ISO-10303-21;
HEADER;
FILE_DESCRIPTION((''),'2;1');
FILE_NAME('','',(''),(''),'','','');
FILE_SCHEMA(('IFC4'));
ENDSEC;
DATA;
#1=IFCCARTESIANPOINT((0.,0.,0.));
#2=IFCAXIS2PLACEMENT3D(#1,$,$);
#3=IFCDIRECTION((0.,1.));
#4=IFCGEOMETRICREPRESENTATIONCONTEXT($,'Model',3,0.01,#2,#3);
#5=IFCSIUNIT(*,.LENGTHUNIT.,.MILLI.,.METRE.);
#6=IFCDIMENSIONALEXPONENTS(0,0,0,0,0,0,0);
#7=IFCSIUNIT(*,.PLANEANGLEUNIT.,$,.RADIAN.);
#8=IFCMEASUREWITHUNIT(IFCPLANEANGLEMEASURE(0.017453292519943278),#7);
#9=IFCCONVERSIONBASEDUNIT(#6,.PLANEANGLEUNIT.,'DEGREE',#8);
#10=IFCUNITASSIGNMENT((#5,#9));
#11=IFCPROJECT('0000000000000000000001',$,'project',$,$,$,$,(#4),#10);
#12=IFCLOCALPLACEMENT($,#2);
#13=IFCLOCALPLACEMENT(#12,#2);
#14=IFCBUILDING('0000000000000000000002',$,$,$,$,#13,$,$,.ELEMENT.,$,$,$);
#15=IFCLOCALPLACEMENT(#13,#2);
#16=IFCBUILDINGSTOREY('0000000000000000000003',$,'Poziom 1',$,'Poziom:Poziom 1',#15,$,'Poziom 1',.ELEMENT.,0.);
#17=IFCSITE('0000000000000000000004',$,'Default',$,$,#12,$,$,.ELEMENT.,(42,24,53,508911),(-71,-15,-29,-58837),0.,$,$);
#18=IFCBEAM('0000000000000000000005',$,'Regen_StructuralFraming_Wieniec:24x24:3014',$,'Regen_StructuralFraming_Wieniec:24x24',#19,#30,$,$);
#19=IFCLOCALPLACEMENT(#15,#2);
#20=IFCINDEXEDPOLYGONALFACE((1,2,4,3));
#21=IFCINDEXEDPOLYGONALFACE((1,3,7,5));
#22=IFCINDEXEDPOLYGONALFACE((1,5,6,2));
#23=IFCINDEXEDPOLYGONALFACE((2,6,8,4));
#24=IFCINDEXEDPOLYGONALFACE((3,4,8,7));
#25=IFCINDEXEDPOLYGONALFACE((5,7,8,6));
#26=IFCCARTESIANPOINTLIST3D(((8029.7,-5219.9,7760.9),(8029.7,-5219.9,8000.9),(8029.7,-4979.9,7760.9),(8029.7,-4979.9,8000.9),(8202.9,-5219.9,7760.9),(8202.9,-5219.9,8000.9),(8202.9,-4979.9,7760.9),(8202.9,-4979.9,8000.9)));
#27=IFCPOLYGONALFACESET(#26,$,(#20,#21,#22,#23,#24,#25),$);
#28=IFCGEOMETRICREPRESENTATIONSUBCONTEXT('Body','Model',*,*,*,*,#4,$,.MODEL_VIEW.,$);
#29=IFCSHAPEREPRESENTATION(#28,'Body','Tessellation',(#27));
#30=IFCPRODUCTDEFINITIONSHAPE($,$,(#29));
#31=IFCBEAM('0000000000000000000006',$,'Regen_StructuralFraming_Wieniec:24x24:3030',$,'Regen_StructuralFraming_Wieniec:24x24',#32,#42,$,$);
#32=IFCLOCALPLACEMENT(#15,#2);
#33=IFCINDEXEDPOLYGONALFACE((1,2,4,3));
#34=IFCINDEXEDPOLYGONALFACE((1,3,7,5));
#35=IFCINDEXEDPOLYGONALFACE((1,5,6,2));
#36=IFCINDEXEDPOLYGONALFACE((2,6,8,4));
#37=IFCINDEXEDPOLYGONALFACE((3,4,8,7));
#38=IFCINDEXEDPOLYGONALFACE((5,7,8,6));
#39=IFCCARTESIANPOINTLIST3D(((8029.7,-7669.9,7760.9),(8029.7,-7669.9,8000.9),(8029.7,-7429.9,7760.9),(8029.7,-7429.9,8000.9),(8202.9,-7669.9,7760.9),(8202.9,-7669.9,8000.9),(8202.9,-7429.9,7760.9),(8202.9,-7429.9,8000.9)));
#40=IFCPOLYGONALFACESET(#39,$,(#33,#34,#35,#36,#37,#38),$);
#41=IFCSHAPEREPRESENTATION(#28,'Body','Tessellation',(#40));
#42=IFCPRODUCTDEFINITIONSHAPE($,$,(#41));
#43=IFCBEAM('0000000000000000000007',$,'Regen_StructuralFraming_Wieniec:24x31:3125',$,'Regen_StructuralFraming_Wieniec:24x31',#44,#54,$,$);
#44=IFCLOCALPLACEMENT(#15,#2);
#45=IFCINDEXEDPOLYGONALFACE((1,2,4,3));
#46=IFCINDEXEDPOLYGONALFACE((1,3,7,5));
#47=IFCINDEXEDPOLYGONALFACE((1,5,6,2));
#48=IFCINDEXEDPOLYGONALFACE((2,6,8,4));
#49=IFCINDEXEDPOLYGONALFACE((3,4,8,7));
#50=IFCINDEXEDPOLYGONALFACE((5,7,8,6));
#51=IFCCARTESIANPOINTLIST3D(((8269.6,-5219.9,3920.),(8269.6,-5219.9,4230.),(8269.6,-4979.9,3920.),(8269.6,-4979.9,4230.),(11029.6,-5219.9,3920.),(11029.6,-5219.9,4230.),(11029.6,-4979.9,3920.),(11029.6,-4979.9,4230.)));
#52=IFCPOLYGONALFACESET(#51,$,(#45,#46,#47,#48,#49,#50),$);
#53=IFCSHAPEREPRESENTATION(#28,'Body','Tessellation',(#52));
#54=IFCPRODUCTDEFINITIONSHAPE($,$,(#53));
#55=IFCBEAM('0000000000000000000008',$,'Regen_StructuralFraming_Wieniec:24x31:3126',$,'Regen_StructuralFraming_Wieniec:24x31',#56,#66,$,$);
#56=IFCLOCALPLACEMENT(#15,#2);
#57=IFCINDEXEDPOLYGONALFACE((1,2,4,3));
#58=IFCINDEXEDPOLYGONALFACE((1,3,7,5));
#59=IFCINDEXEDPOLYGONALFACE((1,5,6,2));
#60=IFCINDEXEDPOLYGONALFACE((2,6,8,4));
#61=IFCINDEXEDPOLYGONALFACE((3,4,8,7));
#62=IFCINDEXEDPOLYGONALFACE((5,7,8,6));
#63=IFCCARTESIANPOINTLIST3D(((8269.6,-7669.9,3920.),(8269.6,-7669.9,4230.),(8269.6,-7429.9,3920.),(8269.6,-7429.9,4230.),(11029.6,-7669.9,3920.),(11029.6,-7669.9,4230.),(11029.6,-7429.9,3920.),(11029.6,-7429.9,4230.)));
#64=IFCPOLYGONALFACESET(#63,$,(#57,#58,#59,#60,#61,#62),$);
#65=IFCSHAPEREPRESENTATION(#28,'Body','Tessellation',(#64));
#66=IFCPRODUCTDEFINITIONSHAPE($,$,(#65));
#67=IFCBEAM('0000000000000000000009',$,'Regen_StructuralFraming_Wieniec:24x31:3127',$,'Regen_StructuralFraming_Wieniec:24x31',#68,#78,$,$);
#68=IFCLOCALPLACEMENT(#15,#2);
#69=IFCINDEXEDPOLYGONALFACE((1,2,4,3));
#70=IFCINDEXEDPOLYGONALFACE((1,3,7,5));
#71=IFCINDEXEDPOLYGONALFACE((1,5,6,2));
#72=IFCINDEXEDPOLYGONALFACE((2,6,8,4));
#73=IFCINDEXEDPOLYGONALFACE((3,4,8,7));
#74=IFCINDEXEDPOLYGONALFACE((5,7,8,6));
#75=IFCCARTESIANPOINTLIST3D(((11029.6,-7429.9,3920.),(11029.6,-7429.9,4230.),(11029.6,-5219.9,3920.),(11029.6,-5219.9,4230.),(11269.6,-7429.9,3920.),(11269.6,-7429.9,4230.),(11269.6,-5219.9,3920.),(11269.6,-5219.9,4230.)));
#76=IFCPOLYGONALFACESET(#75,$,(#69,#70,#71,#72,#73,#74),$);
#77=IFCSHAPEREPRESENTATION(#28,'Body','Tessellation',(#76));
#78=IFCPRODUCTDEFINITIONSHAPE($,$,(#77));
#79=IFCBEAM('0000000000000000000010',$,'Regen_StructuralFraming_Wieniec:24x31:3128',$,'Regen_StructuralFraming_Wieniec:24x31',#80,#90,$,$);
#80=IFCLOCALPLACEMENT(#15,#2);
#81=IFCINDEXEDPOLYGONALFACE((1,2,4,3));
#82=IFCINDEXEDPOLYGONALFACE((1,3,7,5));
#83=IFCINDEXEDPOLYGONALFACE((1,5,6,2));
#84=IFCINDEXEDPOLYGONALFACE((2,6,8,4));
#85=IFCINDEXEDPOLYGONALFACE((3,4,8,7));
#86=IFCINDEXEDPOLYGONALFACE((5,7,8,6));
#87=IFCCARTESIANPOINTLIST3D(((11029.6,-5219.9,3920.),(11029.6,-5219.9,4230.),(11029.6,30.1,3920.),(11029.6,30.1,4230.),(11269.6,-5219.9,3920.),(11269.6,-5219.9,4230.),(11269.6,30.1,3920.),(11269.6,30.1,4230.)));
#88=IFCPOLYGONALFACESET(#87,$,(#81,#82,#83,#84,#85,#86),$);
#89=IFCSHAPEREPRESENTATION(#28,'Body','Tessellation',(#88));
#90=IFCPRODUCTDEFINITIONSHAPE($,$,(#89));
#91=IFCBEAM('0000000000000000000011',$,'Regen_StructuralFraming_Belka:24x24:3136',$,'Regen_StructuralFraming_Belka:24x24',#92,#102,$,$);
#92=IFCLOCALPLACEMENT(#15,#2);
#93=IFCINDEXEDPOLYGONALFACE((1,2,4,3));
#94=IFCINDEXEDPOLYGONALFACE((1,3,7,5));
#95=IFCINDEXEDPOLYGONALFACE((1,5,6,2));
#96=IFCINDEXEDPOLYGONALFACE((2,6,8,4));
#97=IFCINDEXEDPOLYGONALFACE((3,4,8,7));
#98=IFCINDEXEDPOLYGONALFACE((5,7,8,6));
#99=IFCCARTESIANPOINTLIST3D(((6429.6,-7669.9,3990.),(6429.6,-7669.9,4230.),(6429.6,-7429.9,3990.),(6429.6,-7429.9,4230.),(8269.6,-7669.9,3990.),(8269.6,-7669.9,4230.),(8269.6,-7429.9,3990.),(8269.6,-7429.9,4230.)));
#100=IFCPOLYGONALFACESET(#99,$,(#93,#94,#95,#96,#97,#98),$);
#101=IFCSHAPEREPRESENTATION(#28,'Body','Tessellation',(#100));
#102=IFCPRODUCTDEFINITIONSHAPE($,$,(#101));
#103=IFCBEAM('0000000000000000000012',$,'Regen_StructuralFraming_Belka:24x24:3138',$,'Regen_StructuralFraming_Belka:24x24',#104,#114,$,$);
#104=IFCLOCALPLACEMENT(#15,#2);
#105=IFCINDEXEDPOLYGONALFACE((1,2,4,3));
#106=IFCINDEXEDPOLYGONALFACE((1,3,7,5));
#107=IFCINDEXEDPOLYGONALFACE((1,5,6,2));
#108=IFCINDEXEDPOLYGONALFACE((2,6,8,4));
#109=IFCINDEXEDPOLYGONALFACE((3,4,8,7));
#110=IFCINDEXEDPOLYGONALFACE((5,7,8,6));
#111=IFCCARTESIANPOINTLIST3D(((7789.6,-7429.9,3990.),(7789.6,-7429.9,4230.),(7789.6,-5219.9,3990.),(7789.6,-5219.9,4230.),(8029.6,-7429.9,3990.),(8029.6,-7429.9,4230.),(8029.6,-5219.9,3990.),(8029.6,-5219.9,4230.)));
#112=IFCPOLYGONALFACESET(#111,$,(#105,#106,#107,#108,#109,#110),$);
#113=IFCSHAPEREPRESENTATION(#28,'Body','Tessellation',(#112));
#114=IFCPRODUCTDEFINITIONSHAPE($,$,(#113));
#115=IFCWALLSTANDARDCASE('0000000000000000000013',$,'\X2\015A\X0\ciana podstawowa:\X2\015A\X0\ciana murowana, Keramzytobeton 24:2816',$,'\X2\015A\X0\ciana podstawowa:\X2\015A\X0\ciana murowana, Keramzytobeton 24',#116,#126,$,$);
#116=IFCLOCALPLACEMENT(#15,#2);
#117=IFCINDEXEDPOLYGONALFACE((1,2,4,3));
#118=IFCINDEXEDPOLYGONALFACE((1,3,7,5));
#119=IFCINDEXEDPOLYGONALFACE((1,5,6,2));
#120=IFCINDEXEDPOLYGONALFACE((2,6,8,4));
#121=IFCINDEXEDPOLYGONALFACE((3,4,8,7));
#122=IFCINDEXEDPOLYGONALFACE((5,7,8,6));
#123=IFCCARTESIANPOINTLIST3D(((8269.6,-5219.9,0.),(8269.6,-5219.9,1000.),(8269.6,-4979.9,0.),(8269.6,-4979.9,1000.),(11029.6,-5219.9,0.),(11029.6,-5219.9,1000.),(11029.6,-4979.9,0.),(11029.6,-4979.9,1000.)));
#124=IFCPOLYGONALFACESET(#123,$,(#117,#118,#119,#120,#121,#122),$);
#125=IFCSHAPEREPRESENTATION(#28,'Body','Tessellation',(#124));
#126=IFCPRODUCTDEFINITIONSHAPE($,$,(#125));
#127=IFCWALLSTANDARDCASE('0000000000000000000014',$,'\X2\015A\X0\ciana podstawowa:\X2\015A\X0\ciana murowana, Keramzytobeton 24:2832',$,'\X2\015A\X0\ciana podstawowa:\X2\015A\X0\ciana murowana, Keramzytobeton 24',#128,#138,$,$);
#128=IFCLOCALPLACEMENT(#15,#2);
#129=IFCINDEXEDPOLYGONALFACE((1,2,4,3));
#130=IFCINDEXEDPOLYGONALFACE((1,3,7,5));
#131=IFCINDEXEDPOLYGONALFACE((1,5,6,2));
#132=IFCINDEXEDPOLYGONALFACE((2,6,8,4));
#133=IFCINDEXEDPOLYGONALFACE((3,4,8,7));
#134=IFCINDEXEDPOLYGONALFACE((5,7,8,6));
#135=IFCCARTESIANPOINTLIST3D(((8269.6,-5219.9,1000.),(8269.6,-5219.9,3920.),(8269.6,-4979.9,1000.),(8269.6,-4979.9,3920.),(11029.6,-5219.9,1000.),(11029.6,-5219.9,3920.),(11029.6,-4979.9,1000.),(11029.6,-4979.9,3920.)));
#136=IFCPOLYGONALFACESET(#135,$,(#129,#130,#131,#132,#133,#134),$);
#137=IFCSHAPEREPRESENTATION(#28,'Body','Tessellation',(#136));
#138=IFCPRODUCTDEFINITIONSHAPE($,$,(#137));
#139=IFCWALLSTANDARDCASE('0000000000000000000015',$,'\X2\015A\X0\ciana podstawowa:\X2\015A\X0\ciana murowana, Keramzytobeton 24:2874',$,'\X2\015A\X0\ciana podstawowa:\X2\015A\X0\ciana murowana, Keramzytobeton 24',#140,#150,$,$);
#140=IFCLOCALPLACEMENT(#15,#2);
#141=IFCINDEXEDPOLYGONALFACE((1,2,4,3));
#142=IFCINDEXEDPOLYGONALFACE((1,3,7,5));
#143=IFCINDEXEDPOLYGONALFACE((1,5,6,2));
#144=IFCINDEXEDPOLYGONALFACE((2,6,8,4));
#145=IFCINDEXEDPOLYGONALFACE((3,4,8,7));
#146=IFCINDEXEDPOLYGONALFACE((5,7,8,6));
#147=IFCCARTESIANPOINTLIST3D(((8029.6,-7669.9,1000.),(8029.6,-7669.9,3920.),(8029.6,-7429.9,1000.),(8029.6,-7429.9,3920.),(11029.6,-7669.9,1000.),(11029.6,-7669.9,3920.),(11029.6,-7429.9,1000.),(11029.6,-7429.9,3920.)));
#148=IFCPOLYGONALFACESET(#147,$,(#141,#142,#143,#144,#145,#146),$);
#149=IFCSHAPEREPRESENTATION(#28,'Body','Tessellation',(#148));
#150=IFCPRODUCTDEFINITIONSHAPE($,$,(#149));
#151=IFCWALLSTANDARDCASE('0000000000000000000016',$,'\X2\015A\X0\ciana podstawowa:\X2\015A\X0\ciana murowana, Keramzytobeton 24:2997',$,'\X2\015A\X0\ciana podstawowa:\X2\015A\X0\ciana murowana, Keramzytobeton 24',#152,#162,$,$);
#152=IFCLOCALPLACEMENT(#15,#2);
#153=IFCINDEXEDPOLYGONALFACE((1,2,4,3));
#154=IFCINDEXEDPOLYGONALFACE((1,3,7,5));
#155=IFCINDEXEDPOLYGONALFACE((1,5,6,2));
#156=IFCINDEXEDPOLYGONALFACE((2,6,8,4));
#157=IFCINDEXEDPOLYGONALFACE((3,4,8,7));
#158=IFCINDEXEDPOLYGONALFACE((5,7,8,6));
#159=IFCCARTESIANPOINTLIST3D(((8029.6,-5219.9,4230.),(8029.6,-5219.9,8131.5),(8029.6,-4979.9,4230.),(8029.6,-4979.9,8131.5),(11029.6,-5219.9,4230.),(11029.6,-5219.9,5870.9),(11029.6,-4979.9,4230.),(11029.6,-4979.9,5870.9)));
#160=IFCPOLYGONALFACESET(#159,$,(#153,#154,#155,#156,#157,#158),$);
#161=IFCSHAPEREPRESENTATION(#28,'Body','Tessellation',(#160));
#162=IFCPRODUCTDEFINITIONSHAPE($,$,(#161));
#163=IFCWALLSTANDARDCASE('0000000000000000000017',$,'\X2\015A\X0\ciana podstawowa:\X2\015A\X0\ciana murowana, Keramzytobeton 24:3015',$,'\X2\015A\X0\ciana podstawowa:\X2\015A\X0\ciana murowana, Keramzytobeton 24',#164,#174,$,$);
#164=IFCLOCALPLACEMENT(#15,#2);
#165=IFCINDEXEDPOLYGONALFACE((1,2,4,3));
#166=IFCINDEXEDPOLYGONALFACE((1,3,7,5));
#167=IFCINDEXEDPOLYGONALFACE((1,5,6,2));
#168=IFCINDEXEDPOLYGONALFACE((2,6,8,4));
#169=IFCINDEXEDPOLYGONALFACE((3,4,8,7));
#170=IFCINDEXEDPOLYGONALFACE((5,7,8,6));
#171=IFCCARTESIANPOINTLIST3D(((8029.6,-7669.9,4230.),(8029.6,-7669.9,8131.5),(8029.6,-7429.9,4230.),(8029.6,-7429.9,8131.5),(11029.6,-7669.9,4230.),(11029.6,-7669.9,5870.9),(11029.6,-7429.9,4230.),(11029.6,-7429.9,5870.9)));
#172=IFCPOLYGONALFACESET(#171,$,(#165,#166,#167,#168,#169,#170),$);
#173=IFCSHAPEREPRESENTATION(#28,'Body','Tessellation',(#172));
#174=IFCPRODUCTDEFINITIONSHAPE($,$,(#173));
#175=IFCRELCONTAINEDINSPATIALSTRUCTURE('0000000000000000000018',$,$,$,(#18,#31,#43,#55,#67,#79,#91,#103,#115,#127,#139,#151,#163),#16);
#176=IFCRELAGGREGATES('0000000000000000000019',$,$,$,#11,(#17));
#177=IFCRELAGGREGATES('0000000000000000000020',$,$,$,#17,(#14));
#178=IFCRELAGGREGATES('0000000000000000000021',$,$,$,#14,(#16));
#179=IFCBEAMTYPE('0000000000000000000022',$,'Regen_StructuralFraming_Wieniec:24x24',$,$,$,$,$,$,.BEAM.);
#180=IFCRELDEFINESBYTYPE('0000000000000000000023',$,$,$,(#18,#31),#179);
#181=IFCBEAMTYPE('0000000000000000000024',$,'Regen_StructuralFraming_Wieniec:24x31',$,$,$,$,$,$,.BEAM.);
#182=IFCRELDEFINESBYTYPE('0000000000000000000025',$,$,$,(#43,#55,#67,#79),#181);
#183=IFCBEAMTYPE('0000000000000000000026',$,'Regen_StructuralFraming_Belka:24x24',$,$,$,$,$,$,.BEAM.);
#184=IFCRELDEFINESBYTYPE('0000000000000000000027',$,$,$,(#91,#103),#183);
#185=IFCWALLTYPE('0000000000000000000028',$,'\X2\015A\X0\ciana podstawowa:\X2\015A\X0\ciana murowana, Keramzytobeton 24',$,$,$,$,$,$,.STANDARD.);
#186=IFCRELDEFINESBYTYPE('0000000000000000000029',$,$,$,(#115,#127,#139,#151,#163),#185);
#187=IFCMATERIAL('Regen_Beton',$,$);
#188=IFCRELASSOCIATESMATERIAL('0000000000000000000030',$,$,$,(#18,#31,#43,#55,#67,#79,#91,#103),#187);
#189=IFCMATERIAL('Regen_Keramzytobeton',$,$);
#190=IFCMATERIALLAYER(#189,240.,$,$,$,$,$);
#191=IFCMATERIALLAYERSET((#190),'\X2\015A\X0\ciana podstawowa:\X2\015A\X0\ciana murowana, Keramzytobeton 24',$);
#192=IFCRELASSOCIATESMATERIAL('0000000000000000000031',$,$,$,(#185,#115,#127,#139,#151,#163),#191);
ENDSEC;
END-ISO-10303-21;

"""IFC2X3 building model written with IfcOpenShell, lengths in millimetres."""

from ifc_helpers import new_model, entity, si_unit, converted_unit, direction, frame, frame_2d, origin, origin_2d_with_axis, place, context, subcontext, project, spatial, rectangle, extrude, clip, halfspace, material, layer, layer_set, layer_usage, type_object, element, save


model = new_model("IFC2X3")

# Units and contexts
model_context = context("Model", 3, precision=0.01, world=origin(), true_north=direction((0.0, 1.0)))
body_context = subcontext(model_context, "Body", "Model", "MODEL_VIEW")
ifc_project = project(units=[si_unit("LENGTHUNIT", "METRE", prefix="MILLI"), converted_unit("PLANEANGLEUNIT", "DEGREE", entity("IfcPlaneAngleMeasure", 0.017453292519943278), si_unit("PLANEANGLEUNIT", "RADIAN"), dimensions=[0, 0, 0, 0, 0, 0, 0])], contexts=[model_context])

# Site, building, storey
site_placement = place(None, origin())
site = spatial("IfcSite", under=ifc_project, at=site_placement, Name="Default", CompositionType="ELEMENT", RefLatitude=(42, 24, 53, 508911), RefLongitude=(-71, -15, -29, -58837), RefElevation=0.0)
building_placement = place(site_placement, origin())
building = spatial("IfcBuilding", under=site, at=building_placement, CompositionType="ELEMENT")
storey_placement = place(building_placement, origin())
storey = spatial("IfcBuildingStorey", under=building, at=storey_placement, Name="Poziom 1", ObjectType="Poziom:Poziom 1", LongName="Poziom 1", CompositionType="ELEMENT", Elevation=0.0)

# Beams
ifc_material_1 = material(Name="Regen_Beton")
beam_type_1 = type_object("IfcBeamType", Name="Regen_StructuralFraming_Wieniec:24x24", PredefinedType="BEAM")
for number, where, z_axis, x_axis, name in (
    (1, (8202.9, -5099.9, 8000.9), (0.0, 0.0, 1.0), (-1.0, 0.0, 0.0), "Regen_StructuralFraming_Wieniec:24x24:3014"),
    (2, (8202.9, -7549.9, 8000.9), (0.0, 0.0, 1.0), (-1.0, 0.0, 0.0), "Regen_StructuralFraming_Wieniec:24x24:3030"),
):
    element("IfcBeam", number, at=place(storey_placement, frame(where, z_axis=z_axis, x_axis=x_axis)), inside=storey, type_object=beam_type_1, material=ifc_material_1, Name=name, ObjectType="Regen_StructuralFraming_Wieniec:24x24", context=body_context, shape_type="SweptSolid", body=[
        extrude(rectangle(XDim=240.0, YDim=240.0, at=frame_2d((0.0, 0.0), x_axis=(1.0, 0.0))), frame((0.0, 0.0, -120.0), z_axis=(1.0, 0.0, 0.0), x_axis=(0.0, 0.0, -1.0)), (0.0, 0.0, 1.0), 173.2),
    ])
beam_type_2 = type_object("IfcBeamType", Name="Regen_StructuralFraming_Wieniec:24x31", PredefinedType="BEAM")
beam_1_placement = place(storey_placement, frame((11029.6, -5099.9, 4230.0), z_axis=(0.0, 0.0, 1.0), x_axis=(-1.0, 0.0, 0.0)))
element("IfcBeam", 3, at=beam_1_placement, inside=storey, type_object=beam_type_2, material=ifc_material_1, Name="Regen_StructuralFraming_Wieniec:24x31:3125", ObjectType="Regen_StructuralFraming_Wieniec:24x31", context=body_context, shape_type="SweptSolid", body=[
    extrude(rectangle(XDim=310.0, YDim=240.0, at=frame_2d((0.0, 0.0), x_axis=(1.0, 0.0))), frame((0.0, 0.0, -155.0), z_axis=(1.0, 0.0, 0.0), x_axis=(0.0, 0.0, -1.0)), (0.0, 0.0, 1.0), 2760.0),
])
beam_2_placement = place(storey_placement, frame((11029.6, -7549.9, 4230.0), z_axis=(0.0, 0.0, 1.0), x_axis=(-1.0, 0.0, 0.0)))
element("IfcBeam", 4, at=beam_2_placement, inside=storey, type_object=beam_type_2, material=ifc_material_1, Name="Regen_StructuralFraming_Wieniec:24x31:3126", ObjectType="Regen_StructuralFraming_Wieniec:24x31", context=body_context, shape_type="SweptSolid", body=[
    extrude(rectangle(XDim=310.0, YDim=240.0, at=frame_2d((0.0, 0.0), x_axis=(1.0, 0.0))), frame((0.0, 0.0, -155.0), z_axis=(1.0, 0.0, 0.0), x_axis=(0.0, 0.0, -1.0)), (0.0, 0.0, 1.0), 2760.0),
])
beam_3_placement = place(storey_placement, frame((11149.6, -7429.9, 4230.0), z_axis=(0.0, 0.0, 1.0), x_axis=(0.0, 1.0, 0.0)))
element("IfcBeam", 5, at=beam_3_placement, inside=storey, type_object=beam_type_2, material=ifc_material_1, Name="Regen_StructuralFraming_Wieniec:24x31:3127", ObjectType="Regen_StructuralFraming_Wieniec:24x31", context=body_context, shape_type="SweptSolid", body=[
    extrude(rectangle(XDim=310.0, YDim=240.0, at=origin_2d_with_axis()), frame((0.0, 0.0, -155.0), z_axis=(1.0, 0.0, 0.0), x_axis=(0.0, 0.0, -1.0)), (0.0, 0.0, 1.0), 2210.0),
])
beam_4_placement = place(storey_placement, frame((11149.6, -5219.9, 4230.0), z_axis=(0.0, 0.0, 1.0), x_axis=(0.0, 1.0, 0.0)))
element("IfcBeam", 6, at=beam_4_placement, inside=storey, type_object=beam_type_2, material=ifc_material_1, Name="Regen_StructuralFraming_Wieniec:24x31:3128", ObjectType="Regen_StructuralFraming_Wieniec:24x31", context=body_context, shape_type="SweptSolid", body=[
    extrude(rectangle(XDim=310.0, YDim=240.0, at=frame_2d((0.0, 0.0), x_axis=(1.0, 0.0))), frame((0.0, 0.0, -155.0), z_axis=(1.0, 0.0, 0.0), x_axis=(0.0, 0.0, -1.0)), (0.0, 0.0, 1.0), 5250.0),
])
beam_type_3 = type_object("IfcBeamType", Name="Regen_StructuralFraming_Belka:24x24", PredefinedType="BEAM")
beam_5_placement = place(storey_placement, frame((6669.5, -7549.9, 4230.0)))
element("IfcBeam", 7, at=beam_5_placement, inside=storey, type_object=beam_type_3, material=ifc_material_1, Name="Regen_StructuralFraming_Belka:24x24:3136", ObjectType="Regen_StructuralFraming_Belka:24x24", context=body_context, shape_type="SweptSolid", body=[
    extrude(rectangle(XDim=240.0, YDim=240.0, at=frame_2d((0.0, 0.0), x_axis=(1.0, 0.0))), frame((-240.0, 0.0, -120.0), z_axis=(1.0, 0.0, 0.0), x_axis=(0.0, 0.0, -1.0)), (0.0, 0.0, 1.0), 1840.0),
])
beam_6_placement = place(storey_placement, frame((7909.6, -7429.9, 4230.0), z_axis=(0.0, 0.0, 1.0), x_axis=(0.0, 1.0, 0.0)))
element("IfcBeam", 8, at=beam_6_placement, inside=storey, type_object=beam_type_3, material=ifc_material_1, Name="Regen_StructuralFraming_Belka:24x24:3138", ObjectType="Regen_StructuralFraming_Belka:24x24", context=body_context, shape_type="SweptSolid", body=[
    extrude(rectangle(XDim=240.0, YDim=240.0, at=frame_2d((0.0, 0.0), x_axis=(1.0, 0.0))), frame((0.0, 0.0, -120.0), z_axis=(1.0, 0.0, 0.0), x_axis=(0.0, 0.0, -1.0)), (0.0, 0.0, 1.0), 2210.0),
])

# Walls
ifc_material_2 = material(Name="Regen_Keramzytobeton")
ifc_layer_1 = layer(ifc_material_2, 240.0)
ifc_layer_set_1 = layer_set([ifc_layer_1], Name="Ściana podstawowa:Ściana murowana, Keramzytobeton 24")
ifc_layer_usage_1 = layer_usage(ifc_layer_set_1, "AXIS2", "NEGATIVE", 120.0)
wall_type_1 = type_object("IfcWallType", Name="Ściana podstawowa:Ściana murowana, Keramzytobeton 24", PredefinedType="STANDARD", material=ifc_layer_set_1)
wall_1_placement = place(storey_placement, frame((11029.6, -5099.9, 0.0), z_axis=(0.0, 0.0, 1.0), x_axis=(-1.0, 0.0, 0.0)))
element("IfcWallStandardCase", 9, at=wall_1_placement, inside=storey, type_object=wall_type_1, material=ifc_layer_usage_1, Name="Ściana podstawowa:Ściana murowana, Keramzytobeton 24:2816", ObjectType="Ściana podstawowa:Ściana murowana, Keramzytobeton 24", context=body_context, shape_type="SweptSolid", body=[
    extrude(rectangle(XDim=2760.0, YDim=240.0, at=frame_2d((1380.0, 0.0), x_axis=(-1.0, 0.0))), origin(), (0.0, 0.0, 1.0), 1000.0),
])
ifc_layer_usage_2 = layer_usage(ifc_layer_set_1, "AXIS2", "NEGATIVE", 120.0)
wall_2_placement = place(storey_placement, frame((8269.6, -5099.9, 1000.0)))
element("IfcWallStandardCase", 10, at=wall_2_placement, inside=storey, type_object=wall_type_1, material=ifc_layer_usage_2, Name="Ściana podstawowa:Ściana murowana, Keramzytobeton 24:2832", ObjectType="Ściana podstawowa:Ściana murowana, Keramzytobeton 24", context=body_context, shape_type="SweptSolid", body=[
    extrude(rectangle(XDim=2760.0, YDim=240.0, at=frame_2d((1380.0, 0.0), x_axis=(-1.0, 0.0))), origin(), (0.0, 0.0, 1.0), 2920.0),
])
ifc_layer_usage_3 = layer_usage(ifc_layer_set_1, "AXIS2", "NEGATIVE", 120.0)
wall_3_placement = place(storey_placement, frame((8029.6, -7549.9, 1000.0)))
element("IfcWallStandardCase", 11, at=wall_3_placement, inside=storey, type_object=wall_type_1, material=ifc_layer_usage_3, Name="Ściana podstawowa:Ściana murowana, Keramzytobeton 24:2874", ObjectType="Ściana podstawowa:Ściana murowana, Keramzytobeton 24", context=body_context, shape_type="SweptSolid", body=[
    extrude(rectangle(XDim=3000.0, YDim=240.0, at=frame_2d((1500.0, 0.0), x_axis=(-1.0, 0.0))), origin(), (0.0, 0.0, 1.0), 2920.0),
])
ifc_layer_usage_4 = layer_usage(ifc_layer_set_1, "AXIS2", "NEGATIVE", 120.0)
wall_4_placement = place(storey_placement, frame((11029.6, -5099.9, 4230.0), z_axis=(0.0, 0.0, 1.0), x_axis=(-1.0, 0.0, 0.0)))
element("IfcWallStandardCase", 12, at=wall_4_placement, inside=storey, type_object=wall_type_1, material=ifc_layer_usage_4, Name="Ściana podstawowa:Ściana murowana, Keramzytobeton 24:2997", ObjectType="Ściana podstawowa:Ściana murowana, Keramzytobeton 24", context=body_context, shape_type="Clipping", body=[
    clip(extrude(rectangle(XDim=3000.0, YDim=240.0, at=frame_2d((1500.0, 0.0), x_axis=(-1.0, 0.0))), origin(), (0.0, 0.0, 1.0), 3901.5), halfspace(frame((0.0, -120.0, 1640.9), z_axis=(-0.601815, 0.0, 0.798636), x_axis=(0.0, 1.0, 0.0)), False)),
])
ifc_layer_usage_5 = layer_usage(ifc_layer_set_1, "AXIS2", "NEGATIVE", 120.0)
wall_5_placement = place(storey_placement, frame((11029.6, -7549.9, 4230.0), z_axis=(0.0, 0.0, 1.0), x_axis=(-1.0, 0.0, 0.0)))
element("IfcWallStandardCase", 13, at=wall_5_placement, inside=storey, type_object=wall_type_1, material=ifc_layer_usage_5, Name="Ściana podstawowa:Ściana murowana, Keramzytobeton 24:3015", ObjectType="Ściana podstawowa:Ściana murowana, Keramzytobeton 24", context=body_context, shape_type="Clipping", body=[
    clip(extrude(rectangle(XDim=3000.0, YDim=240.0, at=frame_2d((1500.0, 0.0), x_axis=(-1.0, 0.0))), origin(), (0.0, 0.0, 1.0), 3901.5), halfspace(frame((0.0, -120.0, 1640.9), z_axis=(-0.601815, 0.0, 0.798636), x_axis=(0.0, 1.0, 0.0)), False)),
])

save(model, "model.ifc")
